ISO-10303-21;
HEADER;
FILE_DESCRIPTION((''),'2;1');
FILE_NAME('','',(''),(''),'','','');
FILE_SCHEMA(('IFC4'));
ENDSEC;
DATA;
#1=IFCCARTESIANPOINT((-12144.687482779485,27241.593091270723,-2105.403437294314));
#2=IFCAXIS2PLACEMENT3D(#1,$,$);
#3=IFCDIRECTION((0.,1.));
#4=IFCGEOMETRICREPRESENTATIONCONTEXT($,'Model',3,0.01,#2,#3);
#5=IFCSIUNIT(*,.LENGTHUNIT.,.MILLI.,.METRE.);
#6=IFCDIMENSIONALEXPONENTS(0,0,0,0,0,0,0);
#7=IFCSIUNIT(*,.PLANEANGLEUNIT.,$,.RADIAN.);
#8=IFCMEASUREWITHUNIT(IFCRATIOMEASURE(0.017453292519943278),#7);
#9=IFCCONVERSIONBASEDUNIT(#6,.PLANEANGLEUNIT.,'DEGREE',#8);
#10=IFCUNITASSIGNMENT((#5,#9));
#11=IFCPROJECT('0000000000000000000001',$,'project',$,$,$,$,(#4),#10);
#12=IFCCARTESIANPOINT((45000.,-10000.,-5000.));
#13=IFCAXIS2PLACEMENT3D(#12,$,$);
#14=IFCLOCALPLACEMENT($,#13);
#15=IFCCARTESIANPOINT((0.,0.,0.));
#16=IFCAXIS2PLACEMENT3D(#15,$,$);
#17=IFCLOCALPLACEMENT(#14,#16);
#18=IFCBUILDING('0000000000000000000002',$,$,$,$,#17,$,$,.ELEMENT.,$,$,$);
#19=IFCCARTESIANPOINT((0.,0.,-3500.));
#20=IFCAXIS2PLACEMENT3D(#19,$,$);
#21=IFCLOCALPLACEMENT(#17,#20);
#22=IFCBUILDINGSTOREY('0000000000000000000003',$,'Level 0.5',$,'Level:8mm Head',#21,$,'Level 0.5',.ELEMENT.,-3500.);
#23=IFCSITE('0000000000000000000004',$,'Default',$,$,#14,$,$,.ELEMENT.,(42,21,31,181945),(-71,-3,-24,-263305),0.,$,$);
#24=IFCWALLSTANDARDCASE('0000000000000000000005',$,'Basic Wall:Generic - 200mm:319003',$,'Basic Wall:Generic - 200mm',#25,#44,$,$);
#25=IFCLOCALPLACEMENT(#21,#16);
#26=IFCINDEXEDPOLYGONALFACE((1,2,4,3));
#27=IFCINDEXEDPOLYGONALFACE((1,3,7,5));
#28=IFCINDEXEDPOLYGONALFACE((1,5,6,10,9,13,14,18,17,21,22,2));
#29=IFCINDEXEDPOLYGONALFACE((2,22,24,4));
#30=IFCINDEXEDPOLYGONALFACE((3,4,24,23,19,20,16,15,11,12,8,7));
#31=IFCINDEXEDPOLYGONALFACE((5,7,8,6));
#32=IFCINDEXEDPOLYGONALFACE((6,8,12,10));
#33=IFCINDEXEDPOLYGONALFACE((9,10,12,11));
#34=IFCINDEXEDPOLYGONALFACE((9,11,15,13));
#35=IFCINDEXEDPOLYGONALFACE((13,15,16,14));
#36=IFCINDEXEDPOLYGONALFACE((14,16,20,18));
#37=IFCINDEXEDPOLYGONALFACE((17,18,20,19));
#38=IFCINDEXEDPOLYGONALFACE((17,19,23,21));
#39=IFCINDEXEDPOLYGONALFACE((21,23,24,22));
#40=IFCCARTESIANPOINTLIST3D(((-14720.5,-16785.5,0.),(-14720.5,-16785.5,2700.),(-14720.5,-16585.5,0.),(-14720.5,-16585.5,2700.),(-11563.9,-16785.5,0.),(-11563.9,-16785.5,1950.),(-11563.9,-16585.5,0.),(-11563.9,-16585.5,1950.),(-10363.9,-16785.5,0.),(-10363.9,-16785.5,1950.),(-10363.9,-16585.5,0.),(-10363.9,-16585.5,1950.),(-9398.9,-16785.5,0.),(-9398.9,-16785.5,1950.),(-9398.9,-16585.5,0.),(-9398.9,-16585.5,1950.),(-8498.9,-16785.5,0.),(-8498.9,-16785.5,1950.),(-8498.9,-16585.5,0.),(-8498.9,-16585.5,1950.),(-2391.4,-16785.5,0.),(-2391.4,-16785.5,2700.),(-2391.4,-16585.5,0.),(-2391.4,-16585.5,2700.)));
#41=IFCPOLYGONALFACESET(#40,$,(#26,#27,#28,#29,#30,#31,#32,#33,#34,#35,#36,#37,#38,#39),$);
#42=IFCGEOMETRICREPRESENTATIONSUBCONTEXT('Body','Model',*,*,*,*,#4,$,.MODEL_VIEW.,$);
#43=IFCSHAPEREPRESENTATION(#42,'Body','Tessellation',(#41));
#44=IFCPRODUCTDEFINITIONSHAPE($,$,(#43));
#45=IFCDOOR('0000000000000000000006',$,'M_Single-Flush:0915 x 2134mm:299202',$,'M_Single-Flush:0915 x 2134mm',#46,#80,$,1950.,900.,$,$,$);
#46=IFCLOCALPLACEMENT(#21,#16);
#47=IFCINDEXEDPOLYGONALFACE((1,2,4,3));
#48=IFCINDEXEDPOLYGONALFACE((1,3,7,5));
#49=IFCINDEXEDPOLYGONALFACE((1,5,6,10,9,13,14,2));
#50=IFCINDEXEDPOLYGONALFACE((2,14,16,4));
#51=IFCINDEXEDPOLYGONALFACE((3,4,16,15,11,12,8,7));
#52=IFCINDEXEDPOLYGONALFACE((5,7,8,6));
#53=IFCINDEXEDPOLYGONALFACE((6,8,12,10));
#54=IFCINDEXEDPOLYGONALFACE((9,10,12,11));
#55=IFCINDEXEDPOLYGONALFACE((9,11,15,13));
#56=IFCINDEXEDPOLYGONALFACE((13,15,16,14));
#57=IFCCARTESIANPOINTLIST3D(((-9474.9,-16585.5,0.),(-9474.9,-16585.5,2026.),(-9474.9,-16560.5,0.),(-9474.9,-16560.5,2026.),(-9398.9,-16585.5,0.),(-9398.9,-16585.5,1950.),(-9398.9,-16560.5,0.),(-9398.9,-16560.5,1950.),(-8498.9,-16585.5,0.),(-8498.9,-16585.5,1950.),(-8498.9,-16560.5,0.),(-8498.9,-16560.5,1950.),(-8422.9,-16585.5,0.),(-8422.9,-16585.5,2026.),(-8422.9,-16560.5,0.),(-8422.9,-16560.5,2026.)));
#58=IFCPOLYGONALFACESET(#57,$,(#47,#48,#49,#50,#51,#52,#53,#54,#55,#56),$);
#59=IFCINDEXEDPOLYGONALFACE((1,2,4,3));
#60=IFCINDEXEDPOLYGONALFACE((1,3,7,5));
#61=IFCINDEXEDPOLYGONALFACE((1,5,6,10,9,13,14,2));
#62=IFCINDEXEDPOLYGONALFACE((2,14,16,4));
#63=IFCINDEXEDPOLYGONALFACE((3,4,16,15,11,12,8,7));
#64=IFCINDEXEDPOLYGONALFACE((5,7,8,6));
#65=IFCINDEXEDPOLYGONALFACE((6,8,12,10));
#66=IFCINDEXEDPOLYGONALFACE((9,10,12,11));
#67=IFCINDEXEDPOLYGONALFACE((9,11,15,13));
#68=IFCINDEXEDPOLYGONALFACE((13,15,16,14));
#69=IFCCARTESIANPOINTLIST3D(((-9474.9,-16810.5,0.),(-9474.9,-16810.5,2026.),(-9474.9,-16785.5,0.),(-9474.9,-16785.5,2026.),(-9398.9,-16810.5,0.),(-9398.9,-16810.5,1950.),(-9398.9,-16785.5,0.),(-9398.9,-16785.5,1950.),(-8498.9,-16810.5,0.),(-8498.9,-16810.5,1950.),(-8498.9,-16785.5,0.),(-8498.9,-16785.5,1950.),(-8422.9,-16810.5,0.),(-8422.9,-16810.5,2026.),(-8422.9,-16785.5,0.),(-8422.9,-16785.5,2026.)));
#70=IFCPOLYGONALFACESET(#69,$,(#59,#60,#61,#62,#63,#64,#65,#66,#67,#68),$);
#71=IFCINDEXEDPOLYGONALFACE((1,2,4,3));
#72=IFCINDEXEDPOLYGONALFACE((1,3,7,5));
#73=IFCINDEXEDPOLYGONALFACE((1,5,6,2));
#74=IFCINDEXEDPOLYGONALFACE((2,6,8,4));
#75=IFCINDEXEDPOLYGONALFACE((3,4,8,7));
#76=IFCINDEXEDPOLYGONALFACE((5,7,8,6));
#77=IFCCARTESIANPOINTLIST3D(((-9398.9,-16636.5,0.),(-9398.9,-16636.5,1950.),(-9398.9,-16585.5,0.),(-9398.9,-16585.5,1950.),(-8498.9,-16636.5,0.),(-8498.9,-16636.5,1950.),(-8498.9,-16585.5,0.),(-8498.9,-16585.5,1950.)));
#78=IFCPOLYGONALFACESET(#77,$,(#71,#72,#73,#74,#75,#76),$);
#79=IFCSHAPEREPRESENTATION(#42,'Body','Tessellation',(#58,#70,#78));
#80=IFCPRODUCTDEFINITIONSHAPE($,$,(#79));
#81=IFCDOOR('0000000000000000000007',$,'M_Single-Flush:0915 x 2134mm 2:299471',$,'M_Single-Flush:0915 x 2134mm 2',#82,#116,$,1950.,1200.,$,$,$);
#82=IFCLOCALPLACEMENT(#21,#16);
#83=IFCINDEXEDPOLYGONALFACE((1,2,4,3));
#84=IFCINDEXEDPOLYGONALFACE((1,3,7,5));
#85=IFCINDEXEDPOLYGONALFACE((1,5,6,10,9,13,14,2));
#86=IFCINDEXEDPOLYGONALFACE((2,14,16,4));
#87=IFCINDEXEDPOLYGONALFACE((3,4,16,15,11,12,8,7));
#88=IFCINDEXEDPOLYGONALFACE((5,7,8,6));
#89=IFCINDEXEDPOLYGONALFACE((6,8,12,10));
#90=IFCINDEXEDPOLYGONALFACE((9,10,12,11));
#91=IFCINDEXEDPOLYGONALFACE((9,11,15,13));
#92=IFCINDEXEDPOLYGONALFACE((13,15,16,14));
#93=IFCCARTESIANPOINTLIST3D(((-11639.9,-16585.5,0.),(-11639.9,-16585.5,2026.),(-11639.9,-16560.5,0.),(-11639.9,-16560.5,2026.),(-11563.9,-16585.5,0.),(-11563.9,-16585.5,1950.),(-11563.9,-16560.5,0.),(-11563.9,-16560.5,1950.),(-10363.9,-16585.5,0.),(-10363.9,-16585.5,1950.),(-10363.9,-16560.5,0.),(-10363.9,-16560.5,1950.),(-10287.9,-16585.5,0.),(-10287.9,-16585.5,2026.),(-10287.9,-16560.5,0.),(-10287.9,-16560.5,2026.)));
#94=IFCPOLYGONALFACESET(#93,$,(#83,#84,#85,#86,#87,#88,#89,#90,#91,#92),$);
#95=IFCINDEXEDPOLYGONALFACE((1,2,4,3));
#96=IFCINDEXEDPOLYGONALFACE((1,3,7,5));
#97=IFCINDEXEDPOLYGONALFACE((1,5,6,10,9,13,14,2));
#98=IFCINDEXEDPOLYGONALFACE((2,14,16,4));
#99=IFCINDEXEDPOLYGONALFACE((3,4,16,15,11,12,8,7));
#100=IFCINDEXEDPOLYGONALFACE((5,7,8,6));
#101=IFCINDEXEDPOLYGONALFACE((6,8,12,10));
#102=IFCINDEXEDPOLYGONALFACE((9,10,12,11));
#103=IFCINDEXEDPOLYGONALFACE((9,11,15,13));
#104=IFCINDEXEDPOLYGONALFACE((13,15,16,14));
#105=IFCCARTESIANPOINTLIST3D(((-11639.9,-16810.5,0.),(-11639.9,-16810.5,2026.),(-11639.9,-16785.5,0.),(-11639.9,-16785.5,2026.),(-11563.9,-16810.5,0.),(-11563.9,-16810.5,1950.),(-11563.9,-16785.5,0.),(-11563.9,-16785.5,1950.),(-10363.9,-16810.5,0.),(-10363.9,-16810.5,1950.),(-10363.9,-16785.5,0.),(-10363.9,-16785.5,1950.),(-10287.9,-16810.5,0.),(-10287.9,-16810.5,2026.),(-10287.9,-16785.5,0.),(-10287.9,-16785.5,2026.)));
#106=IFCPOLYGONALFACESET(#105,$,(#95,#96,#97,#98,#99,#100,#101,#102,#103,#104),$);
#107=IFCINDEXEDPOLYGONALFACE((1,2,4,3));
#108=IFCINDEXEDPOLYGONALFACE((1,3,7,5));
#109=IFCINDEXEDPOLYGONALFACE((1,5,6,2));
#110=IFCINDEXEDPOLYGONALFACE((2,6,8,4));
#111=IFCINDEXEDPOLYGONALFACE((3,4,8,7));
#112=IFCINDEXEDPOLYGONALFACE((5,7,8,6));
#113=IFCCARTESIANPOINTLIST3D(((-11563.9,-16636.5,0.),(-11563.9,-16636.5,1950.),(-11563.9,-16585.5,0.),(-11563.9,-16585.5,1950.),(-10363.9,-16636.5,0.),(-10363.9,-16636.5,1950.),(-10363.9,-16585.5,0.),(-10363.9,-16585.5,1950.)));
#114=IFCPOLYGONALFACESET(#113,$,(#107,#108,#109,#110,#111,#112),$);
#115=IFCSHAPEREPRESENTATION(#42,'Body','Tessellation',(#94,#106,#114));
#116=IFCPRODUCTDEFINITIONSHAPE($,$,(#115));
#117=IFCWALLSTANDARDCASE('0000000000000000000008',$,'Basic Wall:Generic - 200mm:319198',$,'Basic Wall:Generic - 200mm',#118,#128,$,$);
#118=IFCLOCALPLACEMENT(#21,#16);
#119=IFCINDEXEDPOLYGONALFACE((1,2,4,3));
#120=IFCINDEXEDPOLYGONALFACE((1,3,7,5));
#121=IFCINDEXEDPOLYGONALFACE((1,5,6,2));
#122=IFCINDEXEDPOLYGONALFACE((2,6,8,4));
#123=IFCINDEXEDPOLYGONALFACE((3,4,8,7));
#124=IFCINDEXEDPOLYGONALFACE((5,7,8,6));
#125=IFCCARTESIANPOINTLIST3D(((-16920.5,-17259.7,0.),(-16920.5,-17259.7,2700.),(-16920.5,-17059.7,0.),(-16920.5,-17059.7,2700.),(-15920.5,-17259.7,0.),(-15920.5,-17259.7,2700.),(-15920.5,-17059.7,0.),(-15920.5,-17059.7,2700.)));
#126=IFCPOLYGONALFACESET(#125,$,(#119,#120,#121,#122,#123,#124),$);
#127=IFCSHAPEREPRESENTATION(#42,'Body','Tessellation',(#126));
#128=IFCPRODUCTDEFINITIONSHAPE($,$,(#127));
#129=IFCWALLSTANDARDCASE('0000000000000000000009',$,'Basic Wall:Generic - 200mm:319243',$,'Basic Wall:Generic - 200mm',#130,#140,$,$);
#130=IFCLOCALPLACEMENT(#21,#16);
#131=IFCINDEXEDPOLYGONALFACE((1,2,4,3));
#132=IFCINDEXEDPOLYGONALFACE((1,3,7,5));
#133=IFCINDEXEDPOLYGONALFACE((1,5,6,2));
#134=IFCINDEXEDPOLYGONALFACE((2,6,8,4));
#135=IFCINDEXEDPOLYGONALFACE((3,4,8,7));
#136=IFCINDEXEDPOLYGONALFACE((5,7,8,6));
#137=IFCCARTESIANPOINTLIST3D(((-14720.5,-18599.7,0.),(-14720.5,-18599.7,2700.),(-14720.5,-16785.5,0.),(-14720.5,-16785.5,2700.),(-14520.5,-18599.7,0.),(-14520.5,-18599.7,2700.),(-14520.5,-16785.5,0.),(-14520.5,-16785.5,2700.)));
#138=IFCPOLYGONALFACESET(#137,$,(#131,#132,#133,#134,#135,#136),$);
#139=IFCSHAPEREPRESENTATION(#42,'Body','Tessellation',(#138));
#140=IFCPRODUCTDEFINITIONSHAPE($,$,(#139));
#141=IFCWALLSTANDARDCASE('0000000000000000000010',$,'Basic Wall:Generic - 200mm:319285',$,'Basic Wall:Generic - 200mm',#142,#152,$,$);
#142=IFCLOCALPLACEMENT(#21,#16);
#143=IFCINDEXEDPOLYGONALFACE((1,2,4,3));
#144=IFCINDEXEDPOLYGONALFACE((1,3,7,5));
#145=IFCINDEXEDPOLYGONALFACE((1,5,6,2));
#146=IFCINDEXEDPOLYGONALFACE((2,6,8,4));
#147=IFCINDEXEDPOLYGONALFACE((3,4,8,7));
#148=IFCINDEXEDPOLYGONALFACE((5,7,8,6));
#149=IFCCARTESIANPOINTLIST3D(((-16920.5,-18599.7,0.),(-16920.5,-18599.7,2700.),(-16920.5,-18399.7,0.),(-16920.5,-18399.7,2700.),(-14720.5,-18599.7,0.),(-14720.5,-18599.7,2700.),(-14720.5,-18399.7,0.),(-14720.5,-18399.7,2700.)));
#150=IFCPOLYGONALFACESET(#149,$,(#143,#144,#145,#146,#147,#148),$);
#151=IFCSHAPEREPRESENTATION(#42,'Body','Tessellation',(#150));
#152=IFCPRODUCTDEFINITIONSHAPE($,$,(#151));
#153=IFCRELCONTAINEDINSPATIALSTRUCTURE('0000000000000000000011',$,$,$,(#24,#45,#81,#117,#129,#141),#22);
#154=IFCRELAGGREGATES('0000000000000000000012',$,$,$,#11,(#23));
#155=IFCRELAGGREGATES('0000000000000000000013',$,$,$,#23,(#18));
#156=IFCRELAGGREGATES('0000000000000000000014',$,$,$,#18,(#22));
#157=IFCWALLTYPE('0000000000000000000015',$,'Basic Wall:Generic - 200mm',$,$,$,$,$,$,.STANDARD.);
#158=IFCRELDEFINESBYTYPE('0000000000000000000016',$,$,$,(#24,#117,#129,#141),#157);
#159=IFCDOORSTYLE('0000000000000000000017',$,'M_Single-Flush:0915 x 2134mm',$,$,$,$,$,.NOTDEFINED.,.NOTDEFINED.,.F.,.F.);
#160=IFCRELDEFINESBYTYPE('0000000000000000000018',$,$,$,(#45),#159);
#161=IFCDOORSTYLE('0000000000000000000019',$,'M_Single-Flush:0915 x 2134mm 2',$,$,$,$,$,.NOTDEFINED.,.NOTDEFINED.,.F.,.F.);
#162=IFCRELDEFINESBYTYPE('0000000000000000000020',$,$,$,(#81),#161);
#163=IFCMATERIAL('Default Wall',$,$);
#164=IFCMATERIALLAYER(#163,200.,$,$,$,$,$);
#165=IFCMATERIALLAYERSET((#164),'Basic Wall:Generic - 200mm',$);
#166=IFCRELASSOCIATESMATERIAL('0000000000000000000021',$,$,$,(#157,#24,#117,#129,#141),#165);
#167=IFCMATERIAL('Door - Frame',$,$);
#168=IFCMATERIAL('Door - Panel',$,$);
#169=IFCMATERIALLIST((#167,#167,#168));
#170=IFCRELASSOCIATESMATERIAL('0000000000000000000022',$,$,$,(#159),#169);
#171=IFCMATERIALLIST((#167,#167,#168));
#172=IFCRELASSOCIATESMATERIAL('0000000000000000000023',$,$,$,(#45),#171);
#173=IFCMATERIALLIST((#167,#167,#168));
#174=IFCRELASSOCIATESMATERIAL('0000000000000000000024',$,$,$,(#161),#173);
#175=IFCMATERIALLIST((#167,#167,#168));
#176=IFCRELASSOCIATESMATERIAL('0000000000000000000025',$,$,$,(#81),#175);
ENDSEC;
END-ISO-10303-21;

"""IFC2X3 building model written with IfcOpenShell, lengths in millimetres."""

from ifc_helpers import new_model, entity, si_unit, converted_unit, direction, frame, frame_2d, origin, place, context, subcontext, project, spatial, polyline, rectangle, outline, extrude, source, transform, mapped, material, material_list, layer, layer_set, layer_usage, type_object, type_shapes, element, fill, save


model = new_model("IFC2X3")

# Units and contexts
model_context = context("Model", 3, precision=0.01, world=frame((-12144.687482779485, 27241.593091270723, -2105.403437294314)), true_north=direction((0.0, 1.0)))
body_context = subcontext(model_context, "Body", "Model", "MODEL_VIEW")
ifc_project = project(units=[si_unit("LENGTHUNIT", "METRE", prefix="MILLI"), converted_unit("PLANEANGLEUNIT", "DEGREE", entity("IfcRatioMeasure", 0.017453292519943278), si_unit("PLANEANGLEUNIT", "RADIAN"), dimensions=[0, 0, 0, 0, 0, 0, 0])], contexts=[model_context])

# Site, building, storey
site_placement = place(None, frame((45000.0, -10000.0, -5000.0)))
site = spatial("IfcSite", under=ifc_project, at=site_placement, Name="Default", CompositionType="ELEMENT", RefLatitude=(42, 21, 31, 181945), RefLongitude=(-71, -3, -24, -263305), RefElevation=0.0)
building_placement = place(site_placement, origin())
building = spatial("IfcBuilding", under=site, at=building_placement, CompositionType="ELEMENT")
storey_placement = place(building_placement, frame((0.0, 0.0, -3500.0)))
storey = spatial("IfcBuildingStorey", under=building, at=storey_placement, Name="Level 0.5", ObjectType="Level:8mm Head", LongName="Level 0.5", CompositionType="ELEMENT", Elevation=-3500.0)

# Shared definitions
ifc_material_1 = material(Name="Default Wall")
ifc_layer_1 = layer(ifc_material_1, 200.0)
ifc_layer_set_1 = layer_set([ifc_layer_1], Name="Basic Wall:Generic - 200mm")
wall_type_1 = type_object("IfcWallType", Name="Basic Wall:Generic - 200mm", PredefinedType="STANDARD", material=ifc_layer_set_1)

# Shared definitions
ifc_material_2 = material(Name="Door - Frame")
ifc_material_3 = material(Name="Door - Panel")
ifc_material_list_1 = material_list([ifc_material_2, ifc_material_2, ifc_material_3])
door_style_1 = type_object("IfcDoorStyle", Name="M_Single-Flush:0915 x 2134mm", ConstructionType="NOTDEFINED", OperationType="NOTDEFINED", ParameterTakesPrecedence=False, Sizeable=False, material=ifc_material_list_1)
shared_shape_1 = source(origin(), body_context, "Body", "SweptSolid", [
    extrude(outline(polyline([(-526.0, -1032.0), (526.0, -1032.0), (526.0, 994.0), (450.0, 994.0), (450.0, -956.0), (-450.0, -956.0), (-450.0, 994.0), (-526.0, 994.0), (-526.0, -1032.0)])), frame((450.0, 225.0, 994.0), z_axis=(0.0, -1.0, 0.0), x_axis=(-1.0, 0.0, 0.0)), (0.0, 0.0, 1.0), 25.0),
    extrude(outline(polyline([(-1032.0, -526.0), (994.0, -526.0), (994.0, -450.0), (-956.0, -450.0), (-956.0, 450.0), (994.0, 450.0), (994.0, 526.0), (-1032.0, 526.0), (-1032.0, -526.0)])), frame((450.0, 0.0, 994.0), z_axis=(0.0, -1.0, 0.0), x_axis=(0.0, 0.0, -1.0)), (0.0, 0.0, 1.0), 25.0),
    extrude(rectangle(XDim=900.0, YDim=51.0, at=frame_2d((0.0, 0.0), x_axis=(1.0, 0.0))), frame((450.0, 174.5, 0.0)), (0.0, 0.0, 1.0), 1950.0),
])
type_shapes(door_style_1, [shared_shape_1])

# Wall, openings, doors
ifc_layer_usage_1 = layer_usage(ifc_layer_set_1, "AXIS2", "NEGATIVE", 100.0)
wall_1_placement = place(storey_placement, frame((-14720.5, -16685.5, 0.0)))
wall_1 = element("IfcWallStandardCase", 1, at=wall_1_placement, inside=storey, type_object=wall_type_1, material=ifc_layer_usage_1, Name="Basic Wall:Generic - 200mm:319003", ObjectType="Basic Wall:Generic - 200mm", context=body_context, shape_type="SweptSolid", body=[
    extrude(rectangle(XDim=12329.1, YDim=200.0, at=frame_2d((6164.6, 0.0), x_axis=(1.0, 0.0))), origin(), (0.0, 0.0, 1.0), 2700.0),
])
opening_1_placement = place(wall_1_placement, frame((5321.6, -100.0, 0.0)))
opening_1 = element("IfcOpeningElement", 2, at=opening_1_placement, cuts=wall_1, ObjectType="Opening", context=body_context, shape_type="SweptSolid", body=[
    extrude(rectangle(XDim=900.0, YDim=1950.0, at=frame_2d((975.0, 450.0), x_axis=(0.0, -1.0))), frame((0.0, 0.0, 0.0), z_axis=(0.0, 1.0, 0.0), x_axis=(0.0, 0.0, 1.0)), (0.0, 0.0, 1.0), 200.0),
])
opening_2_placement = place(wall_1_placement, frame((3156.6, -100.0, 0.0)))
opening_2 = element("IfcOpeningElement", 3, at=opening_2_placement, cuts=wall_1, ObjectType="Opening", context=body_context, shape_type="SweptSolid", body=[
    extrude(rectangle(XDim=1200.0, YDim=1950.0, at=frame_2d((975.0, 600.0), x_axis=(0.0, -1.0))), frame((0.0, 0.0, 0.0), z_axis=(0.0, 1.0, 0.0), x_axis=(0.0, 0.0, 1.0)), (0.0, 0.0, 1.0), 200.0),
])
ifc_material_list_2 = material_list([ifc_material_2, ifc_material_2, ifc_material_3])
door_1_placement = place(opening_1_placement, origin())
door_1 = element("IfcDoor", 4, at=door_1_placement, inside=storey, type_object=door_style_1, material=ifc_material_list_2, Name="M_Single-Flush:0915 x 2134mm:299202", ObjectType="M_Single-Flush:0915 x 2134mm", OverallHeight=1950.0, OverallWidth=900.0, context=body_context, shape_type="MappedRepresentation", body=[
    mapped(shared_shape_1, transform((0.0, 0.0, 0.0), scale=1.0)),
])
fill(opening_1, door_1)
ifc_material_list_3 = material_list([ifc_material_2, ifc_material_2, ifc_material_3])
ifc_material_list_4 = material_list([ifc_material_2, ifc_material_2, ifc_material_3])
door_style_2 = type_object("IfcDoorStyle", Name="M_Single-Flush:0915 x 2134mm 2", ConstructionType="NOTDEFINED", OperationType="NOTDEFINED", ParameterTakesPrecedence=False, Sizeable=False, material=ifc_material_list_4)
shared_shape_2 = source(origin(), body_context, "Body", "SweptSolid", [
    extrude(outline(polyline([(-676.0, -1032.0), (676.0, -1032.0), (676.0, 994.0), (600.0, 994.0), (600.0, -956.0), (-600.0, -956.0), (-600.0, 994.0), (-676.0, 994.0), (-676.0, -1032.0)])), frame((600.0, 225.0, 994.0), z_axis=(0.0, -1.0, 0.0), x_axis=(-1.0, 0.0, 0.0)), (0.0, 0.0, 1.0), 25.0),
    extrude(outline(polyline([(-1032.0, -676.0), (994.0, -676.0), (994.0, -600.0), (-956.0, -600.0), (-956.0, 600.0), (994.0, 600.0), (994.0, 676.0), (-1032.0, 676.0), (-1032.0, -676.0)])), frame((600.0, 0.0, 994.0), z_axis=(0.0, -1.0, 0.0), x_axis=(0.0, 0.0, -1.0)), (0.0, 0.0, 1.0), 25.0),
    extrude(rectangle(XDim=1200.0, YDim=51.0, at=frame_2d((0.0, 0.0), x_axis=(1.0, 0.0))), frame((600.0, 174.5, 0.0)), (0.0, 0.0, 1.0), 1950.0),
])
type_shapes(door_style_2, [shared_shape_2])
door_2_placement = place(opening_2_placement, origin())
door_2 = element("IfcDoor", 5, at=door_2_placement, inside=storey, type_object=door_style_2, material=ifc_material_list_3, Name="M_Single-Flush:0915 x 2134mm 2:299471", ObjectType="M_Single-Flush:0915 x 2134mm 2", OverallHeight=1950.0, OverallWidth=1200.0, context=body_context, shape_type="MappedRepresentation", body=[
    mapped(shared_shape_2, transform((0.0, 0.0, 0.0), scale=1.0)),
])
fill(opening_2, door_2)

# Walls
ifc_layer_usage_2 = layer_usage(ifc_layer_set_1, "AXIS2", "NEGATIVE", 100.0)
wall_2_placement = place(storey_placement, frame((-15920.5, -17159.7, 0.0), z_axis=(0.0, 0.0, 1.0), x_axis=(-1.0, 0.0, 0.0)))
element("IfcWallStandardCase", 6, at=wall_2_placement, inside=storey, type_object=wall_type_1, material=ifc_layer_usage_2, Name="Basic Wall:Generic - 200mm:319198", ObjectType="Basic Wall:Generic - 200mm", context=body_context, shape_type="SweptSolid", body=[
    extrude(rectangle(XDim=1000.0, YDim=200.0, at=frame_2d((500.0, 0.0), x_axis=(-1.0, 0.0))), origin(), (0.0, 0.0, 1.0), 2700.0),
])
ifc_layer_usage_3 = layer_usage(ifc_layer_set_1, "AXIS2", "NEGATIVE", 100.0)
wall_3_placement = place(storey_placement, frame((-14620.5, -16785.5, 0.0), z_axis=(0.0, 0.0, 1.0), x_axis=(0.0, -1.0, 0.0)))
element("IfcWallStandardCase", 7, at=wall_3_placement, inside=storey, type_object=wall_type_1, material=ifc_layer_usage_3, Name="Basic Wall:Generic - 200mm:319243", ObjectType="Basic Wall:Generic - 200mm", context=body_context, shape_type="SweptSolid", body=[
    extrude(rectangle(XDim=1814.2, YDim=200.0, at=frame_2d((907.1, 0.0), x_axis=(-1.0, 0.0))), origin(), (0.0, 0.0, 1.0), 2700.0),
])
ifc_layer_usage_4 = layer_usage(ifc_layer_set_1, "AXIS2", "NEGATIVE", 100.0)
wall_4_placement = place(storey_placement, frame((-14720.5, -18499.7, 0.0), z_axis=(0.0, 0.0, 1.0), x_axis=(-1.0, 0.0, 0.0)))
element("IfcWallStandardCase", 8, at=wall_4_placement, inside=storey, type_object=wall_type_1, material=ifc_layer_usage_4, Name="Basic Wall:Generic - 200mm:319285", ObjectType="Basic Wall:Generic - 200mm", context=body_context, shape_type="SweptSolid", body=[
    extrude(rectangle(XDim=2200.0, YDim=200.0, at=frame_2d((1100.0, 0.0), x_axis=(-1.0, 0.0))), origin(), (0.0, 0.0, 1.0), 2700.0),
])

save(model, "model.ifc")
